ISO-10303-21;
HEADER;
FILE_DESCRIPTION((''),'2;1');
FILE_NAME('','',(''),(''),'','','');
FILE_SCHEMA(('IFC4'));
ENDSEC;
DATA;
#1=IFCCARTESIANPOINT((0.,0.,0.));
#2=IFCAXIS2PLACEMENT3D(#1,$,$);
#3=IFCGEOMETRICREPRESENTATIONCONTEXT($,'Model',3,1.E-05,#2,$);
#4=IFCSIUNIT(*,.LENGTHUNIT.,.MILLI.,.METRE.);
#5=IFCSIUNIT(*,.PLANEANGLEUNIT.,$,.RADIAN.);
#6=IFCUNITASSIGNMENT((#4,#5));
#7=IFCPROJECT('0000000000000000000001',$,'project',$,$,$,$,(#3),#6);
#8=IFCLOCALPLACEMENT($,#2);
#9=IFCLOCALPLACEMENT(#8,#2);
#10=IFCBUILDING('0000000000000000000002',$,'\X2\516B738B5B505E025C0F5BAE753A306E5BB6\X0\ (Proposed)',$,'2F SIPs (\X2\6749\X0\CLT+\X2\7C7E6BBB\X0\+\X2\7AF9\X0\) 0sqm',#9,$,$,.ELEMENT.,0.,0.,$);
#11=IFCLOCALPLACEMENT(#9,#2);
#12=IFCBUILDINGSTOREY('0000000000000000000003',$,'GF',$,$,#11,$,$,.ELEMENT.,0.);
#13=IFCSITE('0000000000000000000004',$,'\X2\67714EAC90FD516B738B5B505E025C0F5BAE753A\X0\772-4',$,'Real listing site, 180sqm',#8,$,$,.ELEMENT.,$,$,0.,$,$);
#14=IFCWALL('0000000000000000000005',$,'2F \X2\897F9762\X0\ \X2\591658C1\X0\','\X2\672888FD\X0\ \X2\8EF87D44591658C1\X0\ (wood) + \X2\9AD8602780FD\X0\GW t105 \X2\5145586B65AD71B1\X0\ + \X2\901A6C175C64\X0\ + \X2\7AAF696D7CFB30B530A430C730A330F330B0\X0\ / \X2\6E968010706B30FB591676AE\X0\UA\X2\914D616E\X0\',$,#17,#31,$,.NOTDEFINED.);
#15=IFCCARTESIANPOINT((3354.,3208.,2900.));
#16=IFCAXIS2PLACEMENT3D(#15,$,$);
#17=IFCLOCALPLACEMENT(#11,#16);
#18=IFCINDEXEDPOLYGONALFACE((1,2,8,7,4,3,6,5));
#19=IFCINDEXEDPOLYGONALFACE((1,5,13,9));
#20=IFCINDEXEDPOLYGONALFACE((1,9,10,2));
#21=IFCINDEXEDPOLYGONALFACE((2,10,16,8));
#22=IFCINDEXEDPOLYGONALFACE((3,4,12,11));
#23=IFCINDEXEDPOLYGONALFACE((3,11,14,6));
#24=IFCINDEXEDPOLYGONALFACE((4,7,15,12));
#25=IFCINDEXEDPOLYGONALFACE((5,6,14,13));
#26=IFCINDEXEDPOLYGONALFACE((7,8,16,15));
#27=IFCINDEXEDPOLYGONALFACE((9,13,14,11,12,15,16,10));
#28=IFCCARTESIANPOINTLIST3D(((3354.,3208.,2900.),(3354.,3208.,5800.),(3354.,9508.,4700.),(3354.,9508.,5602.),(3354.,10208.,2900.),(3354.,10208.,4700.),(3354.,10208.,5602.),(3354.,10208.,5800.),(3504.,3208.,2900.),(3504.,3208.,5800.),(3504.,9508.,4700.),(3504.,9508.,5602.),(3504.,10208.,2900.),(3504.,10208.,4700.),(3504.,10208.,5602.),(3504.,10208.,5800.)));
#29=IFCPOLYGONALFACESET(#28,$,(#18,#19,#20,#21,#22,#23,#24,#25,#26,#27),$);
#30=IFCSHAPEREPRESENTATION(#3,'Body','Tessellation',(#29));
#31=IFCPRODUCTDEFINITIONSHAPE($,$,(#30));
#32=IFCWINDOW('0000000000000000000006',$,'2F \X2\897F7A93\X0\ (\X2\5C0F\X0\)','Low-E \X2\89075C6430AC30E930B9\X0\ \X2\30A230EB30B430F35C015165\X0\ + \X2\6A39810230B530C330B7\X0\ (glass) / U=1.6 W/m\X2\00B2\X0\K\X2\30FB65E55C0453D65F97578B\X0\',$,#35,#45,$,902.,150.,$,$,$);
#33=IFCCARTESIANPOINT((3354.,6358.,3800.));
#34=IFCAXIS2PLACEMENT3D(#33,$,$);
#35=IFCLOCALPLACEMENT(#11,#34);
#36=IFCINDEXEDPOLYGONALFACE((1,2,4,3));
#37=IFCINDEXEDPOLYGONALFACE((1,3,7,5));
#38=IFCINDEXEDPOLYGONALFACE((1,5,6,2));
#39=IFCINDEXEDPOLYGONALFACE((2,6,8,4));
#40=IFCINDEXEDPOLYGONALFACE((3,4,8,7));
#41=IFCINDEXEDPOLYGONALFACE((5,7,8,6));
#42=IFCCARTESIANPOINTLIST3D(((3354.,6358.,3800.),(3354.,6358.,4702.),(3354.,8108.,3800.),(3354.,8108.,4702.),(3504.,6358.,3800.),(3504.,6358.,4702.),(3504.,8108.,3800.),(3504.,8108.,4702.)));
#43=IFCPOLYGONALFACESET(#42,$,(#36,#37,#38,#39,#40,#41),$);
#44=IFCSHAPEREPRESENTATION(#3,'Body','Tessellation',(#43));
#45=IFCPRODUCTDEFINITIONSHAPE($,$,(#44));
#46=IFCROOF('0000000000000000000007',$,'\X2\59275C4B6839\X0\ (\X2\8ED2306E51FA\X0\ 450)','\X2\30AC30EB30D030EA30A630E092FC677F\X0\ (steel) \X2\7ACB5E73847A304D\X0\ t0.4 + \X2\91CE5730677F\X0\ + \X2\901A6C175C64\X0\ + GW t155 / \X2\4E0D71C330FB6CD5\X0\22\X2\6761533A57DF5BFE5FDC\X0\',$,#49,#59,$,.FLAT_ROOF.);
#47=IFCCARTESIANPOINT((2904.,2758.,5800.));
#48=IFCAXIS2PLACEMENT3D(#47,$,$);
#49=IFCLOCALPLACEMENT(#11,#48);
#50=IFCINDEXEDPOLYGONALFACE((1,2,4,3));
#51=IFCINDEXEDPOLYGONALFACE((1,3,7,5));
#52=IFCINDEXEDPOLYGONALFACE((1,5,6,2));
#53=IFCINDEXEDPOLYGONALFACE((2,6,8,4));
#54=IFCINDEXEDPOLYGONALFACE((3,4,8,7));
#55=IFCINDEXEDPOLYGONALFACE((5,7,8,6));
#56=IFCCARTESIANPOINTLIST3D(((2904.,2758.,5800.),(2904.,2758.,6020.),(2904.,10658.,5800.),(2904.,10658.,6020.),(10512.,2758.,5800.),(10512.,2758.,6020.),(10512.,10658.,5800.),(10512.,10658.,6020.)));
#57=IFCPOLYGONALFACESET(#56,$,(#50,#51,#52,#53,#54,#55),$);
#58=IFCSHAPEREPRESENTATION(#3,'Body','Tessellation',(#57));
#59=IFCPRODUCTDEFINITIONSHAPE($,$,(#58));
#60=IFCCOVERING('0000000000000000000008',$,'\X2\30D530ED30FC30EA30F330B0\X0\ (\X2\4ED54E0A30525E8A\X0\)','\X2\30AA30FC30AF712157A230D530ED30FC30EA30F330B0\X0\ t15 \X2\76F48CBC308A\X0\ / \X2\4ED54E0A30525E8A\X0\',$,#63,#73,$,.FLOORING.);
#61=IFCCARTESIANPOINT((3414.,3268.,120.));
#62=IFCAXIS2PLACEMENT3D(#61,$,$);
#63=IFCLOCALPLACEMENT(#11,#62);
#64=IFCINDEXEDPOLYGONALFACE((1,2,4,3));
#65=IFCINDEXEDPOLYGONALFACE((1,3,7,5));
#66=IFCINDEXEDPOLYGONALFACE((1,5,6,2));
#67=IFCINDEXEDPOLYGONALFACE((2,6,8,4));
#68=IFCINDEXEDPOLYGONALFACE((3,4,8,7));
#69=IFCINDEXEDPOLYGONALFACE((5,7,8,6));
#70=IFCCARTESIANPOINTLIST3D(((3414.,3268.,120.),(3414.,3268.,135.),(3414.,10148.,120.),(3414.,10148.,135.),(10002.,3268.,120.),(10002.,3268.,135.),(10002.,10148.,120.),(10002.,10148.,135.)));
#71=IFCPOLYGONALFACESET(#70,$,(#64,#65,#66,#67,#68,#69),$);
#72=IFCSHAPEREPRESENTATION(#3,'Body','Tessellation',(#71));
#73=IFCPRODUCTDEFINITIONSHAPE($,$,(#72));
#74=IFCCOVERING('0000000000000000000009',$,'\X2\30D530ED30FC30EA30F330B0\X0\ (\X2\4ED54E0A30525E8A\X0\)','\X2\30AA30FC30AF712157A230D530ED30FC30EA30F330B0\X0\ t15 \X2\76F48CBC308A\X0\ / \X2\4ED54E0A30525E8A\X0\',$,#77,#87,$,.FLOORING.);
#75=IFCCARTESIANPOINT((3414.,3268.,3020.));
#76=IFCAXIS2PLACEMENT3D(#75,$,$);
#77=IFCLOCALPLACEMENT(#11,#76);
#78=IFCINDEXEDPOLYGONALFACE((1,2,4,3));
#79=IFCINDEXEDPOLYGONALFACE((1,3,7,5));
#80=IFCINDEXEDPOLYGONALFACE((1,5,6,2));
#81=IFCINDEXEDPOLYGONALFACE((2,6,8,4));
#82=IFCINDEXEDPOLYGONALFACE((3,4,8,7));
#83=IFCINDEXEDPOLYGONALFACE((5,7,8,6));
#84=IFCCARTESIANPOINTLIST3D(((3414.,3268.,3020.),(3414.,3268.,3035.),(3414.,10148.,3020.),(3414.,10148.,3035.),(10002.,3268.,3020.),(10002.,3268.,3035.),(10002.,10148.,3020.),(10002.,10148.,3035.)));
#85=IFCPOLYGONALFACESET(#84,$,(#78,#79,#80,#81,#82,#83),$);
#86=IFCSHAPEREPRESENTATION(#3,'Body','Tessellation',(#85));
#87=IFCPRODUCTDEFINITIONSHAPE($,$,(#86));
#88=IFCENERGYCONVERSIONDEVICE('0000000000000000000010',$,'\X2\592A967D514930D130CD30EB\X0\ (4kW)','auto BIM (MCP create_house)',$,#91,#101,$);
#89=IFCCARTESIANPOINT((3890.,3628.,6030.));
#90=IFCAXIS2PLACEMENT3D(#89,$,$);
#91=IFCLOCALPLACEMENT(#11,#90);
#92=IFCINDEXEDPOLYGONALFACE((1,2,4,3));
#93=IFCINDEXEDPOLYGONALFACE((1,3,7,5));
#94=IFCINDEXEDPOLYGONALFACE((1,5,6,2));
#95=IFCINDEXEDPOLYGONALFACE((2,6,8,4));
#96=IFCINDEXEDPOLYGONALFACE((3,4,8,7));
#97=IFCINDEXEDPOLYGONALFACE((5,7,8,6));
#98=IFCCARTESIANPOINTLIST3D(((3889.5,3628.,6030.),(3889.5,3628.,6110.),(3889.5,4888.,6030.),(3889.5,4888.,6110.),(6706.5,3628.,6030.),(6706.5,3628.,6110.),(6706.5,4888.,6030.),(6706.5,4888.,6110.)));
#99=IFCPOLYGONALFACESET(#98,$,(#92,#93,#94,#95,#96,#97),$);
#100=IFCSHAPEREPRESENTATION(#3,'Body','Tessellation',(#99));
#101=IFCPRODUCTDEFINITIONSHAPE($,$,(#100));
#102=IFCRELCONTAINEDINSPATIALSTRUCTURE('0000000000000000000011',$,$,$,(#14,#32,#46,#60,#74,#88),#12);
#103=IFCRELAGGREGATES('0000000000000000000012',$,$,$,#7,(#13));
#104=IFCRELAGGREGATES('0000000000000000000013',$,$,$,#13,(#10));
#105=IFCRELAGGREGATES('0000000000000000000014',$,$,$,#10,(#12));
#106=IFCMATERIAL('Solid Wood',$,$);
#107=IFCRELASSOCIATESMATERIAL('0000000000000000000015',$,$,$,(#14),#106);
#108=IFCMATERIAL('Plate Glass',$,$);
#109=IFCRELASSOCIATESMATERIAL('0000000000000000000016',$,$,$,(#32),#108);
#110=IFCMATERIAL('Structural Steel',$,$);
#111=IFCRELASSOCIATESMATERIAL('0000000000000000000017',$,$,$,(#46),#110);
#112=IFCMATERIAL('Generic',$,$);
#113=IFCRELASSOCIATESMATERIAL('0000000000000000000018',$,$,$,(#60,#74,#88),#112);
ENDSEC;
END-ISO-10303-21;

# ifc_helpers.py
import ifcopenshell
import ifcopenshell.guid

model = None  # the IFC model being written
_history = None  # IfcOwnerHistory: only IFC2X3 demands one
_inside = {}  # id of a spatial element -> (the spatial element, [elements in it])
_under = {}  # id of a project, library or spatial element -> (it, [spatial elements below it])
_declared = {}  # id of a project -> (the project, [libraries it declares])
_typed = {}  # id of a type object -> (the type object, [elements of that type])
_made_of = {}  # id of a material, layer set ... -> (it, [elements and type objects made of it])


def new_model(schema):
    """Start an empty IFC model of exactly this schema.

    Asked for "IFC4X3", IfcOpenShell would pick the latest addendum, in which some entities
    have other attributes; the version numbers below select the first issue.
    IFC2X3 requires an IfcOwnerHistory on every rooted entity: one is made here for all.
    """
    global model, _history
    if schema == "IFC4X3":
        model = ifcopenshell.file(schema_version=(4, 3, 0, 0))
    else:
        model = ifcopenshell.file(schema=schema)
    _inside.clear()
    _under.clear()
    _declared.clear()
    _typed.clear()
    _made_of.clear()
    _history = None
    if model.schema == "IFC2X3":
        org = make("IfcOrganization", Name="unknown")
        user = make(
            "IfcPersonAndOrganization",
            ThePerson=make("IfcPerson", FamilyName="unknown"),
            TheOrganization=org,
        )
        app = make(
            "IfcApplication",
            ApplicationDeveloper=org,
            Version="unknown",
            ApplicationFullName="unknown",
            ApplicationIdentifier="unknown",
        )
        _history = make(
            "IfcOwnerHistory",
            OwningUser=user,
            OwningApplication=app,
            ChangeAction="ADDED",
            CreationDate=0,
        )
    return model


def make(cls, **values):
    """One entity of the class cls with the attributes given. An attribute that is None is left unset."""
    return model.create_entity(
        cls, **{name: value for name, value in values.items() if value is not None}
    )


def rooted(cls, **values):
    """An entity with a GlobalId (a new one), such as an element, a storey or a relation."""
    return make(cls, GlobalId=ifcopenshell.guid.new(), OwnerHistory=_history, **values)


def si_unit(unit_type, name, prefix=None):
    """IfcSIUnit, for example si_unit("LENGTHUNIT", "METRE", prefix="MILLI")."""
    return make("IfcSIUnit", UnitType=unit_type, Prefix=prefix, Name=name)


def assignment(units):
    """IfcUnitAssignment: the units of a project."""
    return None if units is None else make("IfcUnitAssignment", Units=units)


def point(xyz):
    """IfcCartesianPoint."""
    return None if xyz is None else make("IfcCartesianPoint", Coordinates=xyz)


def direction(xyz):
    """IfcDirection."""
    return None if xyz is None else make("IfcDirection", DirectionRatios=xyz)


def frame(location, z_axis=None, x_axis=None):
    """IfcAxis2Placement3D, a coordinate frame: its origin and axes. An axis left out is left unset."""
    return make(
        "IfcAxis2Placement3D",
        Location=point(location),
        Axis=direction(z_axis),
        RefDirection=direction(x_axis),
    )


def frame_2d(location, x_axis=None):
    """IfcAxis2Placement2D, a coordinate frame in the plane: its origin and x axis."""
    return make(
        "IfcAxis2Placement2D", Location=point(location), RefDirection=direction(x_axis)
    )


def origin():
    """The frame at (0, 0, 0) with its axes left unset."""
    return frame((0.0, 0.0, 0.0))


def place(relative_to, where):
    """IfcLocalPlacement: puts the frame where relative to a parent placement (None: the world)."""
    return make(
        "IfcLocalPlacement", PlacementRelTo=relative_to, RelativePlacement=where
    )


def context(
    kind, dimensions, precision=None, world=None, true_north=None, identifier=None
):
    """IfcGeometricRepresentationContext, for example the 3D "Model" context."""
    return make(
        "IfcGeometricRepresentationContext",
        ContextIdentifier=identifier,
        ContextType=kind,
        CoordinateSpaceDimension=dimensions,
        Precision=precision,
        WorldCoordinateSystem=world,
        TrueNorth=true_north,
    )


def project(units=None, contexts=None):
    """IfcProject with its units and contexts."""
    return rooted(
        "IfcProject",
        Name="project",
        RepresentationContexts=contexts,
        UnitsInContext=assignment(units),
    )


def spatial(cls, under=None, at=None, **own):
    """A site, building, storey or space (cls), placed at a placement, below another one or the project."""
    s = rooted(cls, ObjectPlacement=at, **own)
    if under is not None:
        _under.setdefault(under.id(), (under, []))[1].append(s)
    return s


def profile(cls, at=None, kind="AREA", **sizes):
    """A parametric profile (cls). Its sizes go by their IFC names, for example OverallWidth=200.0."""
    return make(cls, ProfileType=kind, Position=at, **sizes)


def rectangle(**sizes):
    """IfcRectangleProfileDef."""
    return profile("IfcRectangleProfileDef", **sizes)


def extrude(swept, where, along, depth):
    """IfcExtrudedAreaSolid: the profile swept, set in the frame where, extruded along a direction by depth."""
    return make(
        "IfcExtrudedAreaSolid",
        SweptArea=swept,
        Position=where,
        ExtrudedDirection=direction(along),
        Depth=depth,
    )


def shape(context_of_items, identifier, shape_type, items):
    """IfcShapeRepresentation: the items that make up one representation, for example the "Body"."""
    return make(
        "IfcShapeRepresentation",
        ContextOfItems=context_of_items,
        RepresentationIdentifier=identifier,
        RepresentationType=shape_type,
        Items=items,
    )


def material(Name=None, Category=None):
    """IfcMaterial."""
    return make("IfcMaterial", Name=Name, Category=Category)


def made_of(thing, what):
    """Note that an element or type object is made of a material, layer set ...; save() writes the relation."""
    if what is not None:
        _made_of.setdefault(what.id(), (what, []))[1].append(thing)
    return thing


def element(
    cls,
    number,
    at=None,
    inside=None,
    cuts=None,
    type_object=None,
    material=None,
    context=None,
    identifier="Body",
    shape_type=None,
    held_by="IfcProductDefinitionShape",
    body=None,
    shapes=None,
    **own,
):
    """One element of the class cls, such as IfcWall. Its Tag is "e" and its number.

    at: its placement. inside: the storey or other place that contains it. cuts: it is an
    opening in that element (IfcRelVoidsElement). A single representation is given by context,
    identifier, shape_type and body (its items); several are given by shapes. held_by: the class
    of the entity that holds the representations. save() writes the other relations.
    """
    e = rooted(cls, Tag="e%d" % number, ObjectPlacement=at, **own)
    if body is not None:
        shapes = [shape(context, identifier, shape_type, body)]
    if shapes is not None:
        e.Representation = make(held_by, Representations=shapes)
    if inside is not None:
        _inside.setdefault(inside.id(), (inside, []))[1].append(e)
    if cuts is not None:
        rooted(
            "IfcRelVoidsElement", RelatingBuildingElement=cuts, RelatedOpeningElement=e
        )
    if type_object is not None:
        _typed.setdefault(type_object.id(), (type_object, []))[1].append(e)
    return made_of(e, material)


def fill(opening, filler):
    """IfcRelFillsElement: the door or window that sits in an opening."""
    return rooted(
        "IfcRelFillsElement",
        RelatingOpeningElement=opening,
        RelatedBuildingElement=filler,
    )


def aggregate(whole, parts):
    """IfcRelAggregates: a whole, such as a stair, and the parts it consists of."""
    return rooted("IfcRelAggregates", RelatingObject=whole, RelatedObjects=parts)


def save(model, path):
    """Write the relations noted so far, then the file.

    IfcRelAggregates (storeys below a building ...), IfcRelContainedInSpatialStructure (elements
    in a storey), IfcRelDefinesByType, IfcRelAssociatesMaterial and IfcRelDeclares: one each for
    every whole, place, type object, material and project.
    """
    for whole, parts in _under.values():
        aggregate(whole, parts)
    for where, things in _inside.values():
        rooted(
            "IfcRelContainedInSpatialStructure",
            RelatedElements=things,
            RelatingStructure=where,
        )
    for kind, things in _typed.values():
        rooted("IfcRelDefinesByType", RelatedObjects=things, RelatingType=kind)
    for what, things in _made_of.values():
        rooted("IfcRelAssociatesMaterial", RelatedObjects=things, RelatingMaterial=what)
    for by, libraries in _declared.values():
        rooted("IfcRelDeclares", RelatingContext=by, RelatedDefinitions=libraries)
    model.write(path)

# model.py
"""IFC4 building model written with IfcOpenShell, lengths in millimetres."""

from ifc_helpers import new_model, si_unit, frame, frame_2d, origin, place, context, project, spatial, rectangle, extrude, material, element, fill, save


model = new_model("IFC4")

# Units and contexts
model_context = context("Model", 3, precision=1e-05, world=origin())
ifc_project = project(units=[si_unit("LENGTHUNIT", "METRE", prefix="MILLI"), si_unit("PLANEANGLEUNIT", "RADIAN")], contexts=[model_context])

# Site, building, storey
site_placement = place(None, origin())
site = spatial("IfcSite", under=ifc_project, at=site_placement, Name="東京都八王子市小宮町772-4", ObjectType="Real listing site, 180sqm", CompositionType="ELEMENT", RefElevation=0.0)
building_placement = place(site_placement, origin())
building = spatial("IfcBuilding", under=site, at=building_placement, Name="八王子市小宮町の家 (Proposed)", ObjectType="2F SIPs (杉CLT+籾殻+竹) 0sqm", CompositionType="ELEMENT", ElevationOfRefHeight=0.0, ElevationOfTerrain=0.0)
storey_placement = place(building_placement, origin())
storey = spatial("IfcBuildingStorey", under=building, at=storey_placement, Name="GF", CompositionType="ELEMENT", Elevation=0.0)

# Shared definitions
ifc_material_1 = material(Name="Solid Wood")

# Shared definitions
ifc_material_2 = material(Name="Plate Glass")

# Wall, opening, window
wall_1_placement = place(storey_placement, frame((3354.0, 3208.0, 2900.0)))
wall_1 = element("IfcWall", 1, at=wall_1_placement, inside=storey, material=ifc_material_1, Name="2F 西面 外壁", Description="木製 軸組外壁 (wood) + 高性能GW t105 充填断熱 + 通気層 + 窯業系サイディング / 準耐火・外皮UA配慮", PredefinedType="NOTDEFINED", context=model_context, shape_type="SweptSolid", body=[
    extrude(rectangle(XDim=150.0, YDim=7000.0, at=frame_2d((75.0, 3500.0))), frame((3354.0, 3208.0, 2900.0)), (0.0, 0.0, 1.0), 2900.0),
])
opening_1_placement = place(storey_placement, frame((3354.0, 6358.0, 3800.0)))
opening_1 = element("IfcOpeningElement", 2, at=opening_1_placement, cuts=wall_1, PredefinedType="NOTDEFINED", context=model_context, shape_type="SweptSolid", body=[
    extrude(rectangle(XDim=150.0, YDim=1750.0, at=frame_2d((75.0, 875.0))), frame((3354.0, 6358.0, 3800.0)), (0.0, 0.0, 1.0), 902.0),
])
window_1_placement = place(storey_placement, frame((3354.0, 6358.0, 3800.0)))
window_1 = element("IfcWindow", 3, at=window_1_placement, inside=storey, material=ifc_material_2, Name="2F 西窓 (小)", Description="Low-E 複層ガラス アルゴン封入 + 樹脂サッシ (glass) / U=1.6 W/m²K・日射取得型", OverallHeight=902.0, OverallWidth=150.0, context=model_context, shape_type="SweptSolid", body=[
    extrude(rectangle(XDim=150.0, YDim=1750.0, at=frame_2d((75.0, 875.0))), frame((3354.0, 6358.0, 3800.0)), (0.0, 0.0, 1.0), 902.0),
])
fill(opening_1, window_1)

# Roof
ifc_material_3 = material(Name="Structural Steel")
roof_placement = place(storey_placement, frame((2904.0, 2758.0, 5800.0)))
element("IfcRoof", 4, at=roof_placement, inside=storey, material=ifc_material_3, Name="大屋根 (軒の出 450)", Description="ガルバリウム鋼板 (steel) 立平葺き t0.4 + 野地板 + 通気層 + GW t155 / 不燃・法22条区域対応", PredefinedType="FLAT_ROOF", context=model_context, shape_type="SweptSolid", body=[
    extrude(rectangle(XDim=7608.0, YDim=7900.0, at=frame_2d((3804.0, 3950.0))), frame((2904.0, 2758.0, 5800.0)), (0.0, 0.0, 1.0), 220.0),
])

# Coverings
ifc_material_4 = material(Name="Generic")
covering_1_placement = place(storey_placement, frame((3414.0, 3268.0, 120.0)))
element("IfcCovering", 5, at=covering_1_placement, inside=storey, material=ifc_material_4, Name="フローリング (仕上げ床)", Description="オーク無垢フローリング t15 直貼り / 仕上げ床", PredefinedType="FLOORING", context=model_context, shape_type="SweptSolid", body=[
    extrude(rectangle(XDim=6588.0, YDim=6880.0, at=frame_2d((3294.0, 3440.0))), frame((3414.0, 3268.0, 120.0)), (0.0, 0.0, 1.0), 15.0),
])
covering_2_placement = place(storey_placement, frame((3414.0, 3268.0, 3020.0)))
element("IfcCovering", 6, at=covering_2_placement, inside=storey, material=ifc_material_4, Name="フローリング (仕上げ床)", Description="オーク無垢フローリング t15 直貼り / 仕上げ床", PredefinedType="FLOORING", context=model_context, shape_type="SweptSolid", body=[
    extrude(rectangle(XDim=6588.0, YDim=6880.0, at=frame_2d((3294.0, 3440.0))), frame((3414.0, 3268.0, 3020.0)), (0.0, 0.0, 1.0), 15.0),
])

# Energy conversion device
energy_conversion_device_placement = place(storey_placement, frame((3890.0, 3628.0, 6030.0)))
element("IfcEnergyConversionDevice", 7, at=energy_conversion_device_placement, inside=storey, material=ifc_material_4, Name="太陽光パネル (4kW)", Description="auto BIM (MCP create_house)", context=model_context, shape_type="SweptSolid", body=[
    extrude(rectangle(XDim=2817.0, YDim=1260.0, at=frame_2d((1408.0, 630.0))), frame((3890.0, 3628.0, 6030.0)), (0.0, 0.0, 1.0), 80.0),
])

save(model, "model.ifc")
